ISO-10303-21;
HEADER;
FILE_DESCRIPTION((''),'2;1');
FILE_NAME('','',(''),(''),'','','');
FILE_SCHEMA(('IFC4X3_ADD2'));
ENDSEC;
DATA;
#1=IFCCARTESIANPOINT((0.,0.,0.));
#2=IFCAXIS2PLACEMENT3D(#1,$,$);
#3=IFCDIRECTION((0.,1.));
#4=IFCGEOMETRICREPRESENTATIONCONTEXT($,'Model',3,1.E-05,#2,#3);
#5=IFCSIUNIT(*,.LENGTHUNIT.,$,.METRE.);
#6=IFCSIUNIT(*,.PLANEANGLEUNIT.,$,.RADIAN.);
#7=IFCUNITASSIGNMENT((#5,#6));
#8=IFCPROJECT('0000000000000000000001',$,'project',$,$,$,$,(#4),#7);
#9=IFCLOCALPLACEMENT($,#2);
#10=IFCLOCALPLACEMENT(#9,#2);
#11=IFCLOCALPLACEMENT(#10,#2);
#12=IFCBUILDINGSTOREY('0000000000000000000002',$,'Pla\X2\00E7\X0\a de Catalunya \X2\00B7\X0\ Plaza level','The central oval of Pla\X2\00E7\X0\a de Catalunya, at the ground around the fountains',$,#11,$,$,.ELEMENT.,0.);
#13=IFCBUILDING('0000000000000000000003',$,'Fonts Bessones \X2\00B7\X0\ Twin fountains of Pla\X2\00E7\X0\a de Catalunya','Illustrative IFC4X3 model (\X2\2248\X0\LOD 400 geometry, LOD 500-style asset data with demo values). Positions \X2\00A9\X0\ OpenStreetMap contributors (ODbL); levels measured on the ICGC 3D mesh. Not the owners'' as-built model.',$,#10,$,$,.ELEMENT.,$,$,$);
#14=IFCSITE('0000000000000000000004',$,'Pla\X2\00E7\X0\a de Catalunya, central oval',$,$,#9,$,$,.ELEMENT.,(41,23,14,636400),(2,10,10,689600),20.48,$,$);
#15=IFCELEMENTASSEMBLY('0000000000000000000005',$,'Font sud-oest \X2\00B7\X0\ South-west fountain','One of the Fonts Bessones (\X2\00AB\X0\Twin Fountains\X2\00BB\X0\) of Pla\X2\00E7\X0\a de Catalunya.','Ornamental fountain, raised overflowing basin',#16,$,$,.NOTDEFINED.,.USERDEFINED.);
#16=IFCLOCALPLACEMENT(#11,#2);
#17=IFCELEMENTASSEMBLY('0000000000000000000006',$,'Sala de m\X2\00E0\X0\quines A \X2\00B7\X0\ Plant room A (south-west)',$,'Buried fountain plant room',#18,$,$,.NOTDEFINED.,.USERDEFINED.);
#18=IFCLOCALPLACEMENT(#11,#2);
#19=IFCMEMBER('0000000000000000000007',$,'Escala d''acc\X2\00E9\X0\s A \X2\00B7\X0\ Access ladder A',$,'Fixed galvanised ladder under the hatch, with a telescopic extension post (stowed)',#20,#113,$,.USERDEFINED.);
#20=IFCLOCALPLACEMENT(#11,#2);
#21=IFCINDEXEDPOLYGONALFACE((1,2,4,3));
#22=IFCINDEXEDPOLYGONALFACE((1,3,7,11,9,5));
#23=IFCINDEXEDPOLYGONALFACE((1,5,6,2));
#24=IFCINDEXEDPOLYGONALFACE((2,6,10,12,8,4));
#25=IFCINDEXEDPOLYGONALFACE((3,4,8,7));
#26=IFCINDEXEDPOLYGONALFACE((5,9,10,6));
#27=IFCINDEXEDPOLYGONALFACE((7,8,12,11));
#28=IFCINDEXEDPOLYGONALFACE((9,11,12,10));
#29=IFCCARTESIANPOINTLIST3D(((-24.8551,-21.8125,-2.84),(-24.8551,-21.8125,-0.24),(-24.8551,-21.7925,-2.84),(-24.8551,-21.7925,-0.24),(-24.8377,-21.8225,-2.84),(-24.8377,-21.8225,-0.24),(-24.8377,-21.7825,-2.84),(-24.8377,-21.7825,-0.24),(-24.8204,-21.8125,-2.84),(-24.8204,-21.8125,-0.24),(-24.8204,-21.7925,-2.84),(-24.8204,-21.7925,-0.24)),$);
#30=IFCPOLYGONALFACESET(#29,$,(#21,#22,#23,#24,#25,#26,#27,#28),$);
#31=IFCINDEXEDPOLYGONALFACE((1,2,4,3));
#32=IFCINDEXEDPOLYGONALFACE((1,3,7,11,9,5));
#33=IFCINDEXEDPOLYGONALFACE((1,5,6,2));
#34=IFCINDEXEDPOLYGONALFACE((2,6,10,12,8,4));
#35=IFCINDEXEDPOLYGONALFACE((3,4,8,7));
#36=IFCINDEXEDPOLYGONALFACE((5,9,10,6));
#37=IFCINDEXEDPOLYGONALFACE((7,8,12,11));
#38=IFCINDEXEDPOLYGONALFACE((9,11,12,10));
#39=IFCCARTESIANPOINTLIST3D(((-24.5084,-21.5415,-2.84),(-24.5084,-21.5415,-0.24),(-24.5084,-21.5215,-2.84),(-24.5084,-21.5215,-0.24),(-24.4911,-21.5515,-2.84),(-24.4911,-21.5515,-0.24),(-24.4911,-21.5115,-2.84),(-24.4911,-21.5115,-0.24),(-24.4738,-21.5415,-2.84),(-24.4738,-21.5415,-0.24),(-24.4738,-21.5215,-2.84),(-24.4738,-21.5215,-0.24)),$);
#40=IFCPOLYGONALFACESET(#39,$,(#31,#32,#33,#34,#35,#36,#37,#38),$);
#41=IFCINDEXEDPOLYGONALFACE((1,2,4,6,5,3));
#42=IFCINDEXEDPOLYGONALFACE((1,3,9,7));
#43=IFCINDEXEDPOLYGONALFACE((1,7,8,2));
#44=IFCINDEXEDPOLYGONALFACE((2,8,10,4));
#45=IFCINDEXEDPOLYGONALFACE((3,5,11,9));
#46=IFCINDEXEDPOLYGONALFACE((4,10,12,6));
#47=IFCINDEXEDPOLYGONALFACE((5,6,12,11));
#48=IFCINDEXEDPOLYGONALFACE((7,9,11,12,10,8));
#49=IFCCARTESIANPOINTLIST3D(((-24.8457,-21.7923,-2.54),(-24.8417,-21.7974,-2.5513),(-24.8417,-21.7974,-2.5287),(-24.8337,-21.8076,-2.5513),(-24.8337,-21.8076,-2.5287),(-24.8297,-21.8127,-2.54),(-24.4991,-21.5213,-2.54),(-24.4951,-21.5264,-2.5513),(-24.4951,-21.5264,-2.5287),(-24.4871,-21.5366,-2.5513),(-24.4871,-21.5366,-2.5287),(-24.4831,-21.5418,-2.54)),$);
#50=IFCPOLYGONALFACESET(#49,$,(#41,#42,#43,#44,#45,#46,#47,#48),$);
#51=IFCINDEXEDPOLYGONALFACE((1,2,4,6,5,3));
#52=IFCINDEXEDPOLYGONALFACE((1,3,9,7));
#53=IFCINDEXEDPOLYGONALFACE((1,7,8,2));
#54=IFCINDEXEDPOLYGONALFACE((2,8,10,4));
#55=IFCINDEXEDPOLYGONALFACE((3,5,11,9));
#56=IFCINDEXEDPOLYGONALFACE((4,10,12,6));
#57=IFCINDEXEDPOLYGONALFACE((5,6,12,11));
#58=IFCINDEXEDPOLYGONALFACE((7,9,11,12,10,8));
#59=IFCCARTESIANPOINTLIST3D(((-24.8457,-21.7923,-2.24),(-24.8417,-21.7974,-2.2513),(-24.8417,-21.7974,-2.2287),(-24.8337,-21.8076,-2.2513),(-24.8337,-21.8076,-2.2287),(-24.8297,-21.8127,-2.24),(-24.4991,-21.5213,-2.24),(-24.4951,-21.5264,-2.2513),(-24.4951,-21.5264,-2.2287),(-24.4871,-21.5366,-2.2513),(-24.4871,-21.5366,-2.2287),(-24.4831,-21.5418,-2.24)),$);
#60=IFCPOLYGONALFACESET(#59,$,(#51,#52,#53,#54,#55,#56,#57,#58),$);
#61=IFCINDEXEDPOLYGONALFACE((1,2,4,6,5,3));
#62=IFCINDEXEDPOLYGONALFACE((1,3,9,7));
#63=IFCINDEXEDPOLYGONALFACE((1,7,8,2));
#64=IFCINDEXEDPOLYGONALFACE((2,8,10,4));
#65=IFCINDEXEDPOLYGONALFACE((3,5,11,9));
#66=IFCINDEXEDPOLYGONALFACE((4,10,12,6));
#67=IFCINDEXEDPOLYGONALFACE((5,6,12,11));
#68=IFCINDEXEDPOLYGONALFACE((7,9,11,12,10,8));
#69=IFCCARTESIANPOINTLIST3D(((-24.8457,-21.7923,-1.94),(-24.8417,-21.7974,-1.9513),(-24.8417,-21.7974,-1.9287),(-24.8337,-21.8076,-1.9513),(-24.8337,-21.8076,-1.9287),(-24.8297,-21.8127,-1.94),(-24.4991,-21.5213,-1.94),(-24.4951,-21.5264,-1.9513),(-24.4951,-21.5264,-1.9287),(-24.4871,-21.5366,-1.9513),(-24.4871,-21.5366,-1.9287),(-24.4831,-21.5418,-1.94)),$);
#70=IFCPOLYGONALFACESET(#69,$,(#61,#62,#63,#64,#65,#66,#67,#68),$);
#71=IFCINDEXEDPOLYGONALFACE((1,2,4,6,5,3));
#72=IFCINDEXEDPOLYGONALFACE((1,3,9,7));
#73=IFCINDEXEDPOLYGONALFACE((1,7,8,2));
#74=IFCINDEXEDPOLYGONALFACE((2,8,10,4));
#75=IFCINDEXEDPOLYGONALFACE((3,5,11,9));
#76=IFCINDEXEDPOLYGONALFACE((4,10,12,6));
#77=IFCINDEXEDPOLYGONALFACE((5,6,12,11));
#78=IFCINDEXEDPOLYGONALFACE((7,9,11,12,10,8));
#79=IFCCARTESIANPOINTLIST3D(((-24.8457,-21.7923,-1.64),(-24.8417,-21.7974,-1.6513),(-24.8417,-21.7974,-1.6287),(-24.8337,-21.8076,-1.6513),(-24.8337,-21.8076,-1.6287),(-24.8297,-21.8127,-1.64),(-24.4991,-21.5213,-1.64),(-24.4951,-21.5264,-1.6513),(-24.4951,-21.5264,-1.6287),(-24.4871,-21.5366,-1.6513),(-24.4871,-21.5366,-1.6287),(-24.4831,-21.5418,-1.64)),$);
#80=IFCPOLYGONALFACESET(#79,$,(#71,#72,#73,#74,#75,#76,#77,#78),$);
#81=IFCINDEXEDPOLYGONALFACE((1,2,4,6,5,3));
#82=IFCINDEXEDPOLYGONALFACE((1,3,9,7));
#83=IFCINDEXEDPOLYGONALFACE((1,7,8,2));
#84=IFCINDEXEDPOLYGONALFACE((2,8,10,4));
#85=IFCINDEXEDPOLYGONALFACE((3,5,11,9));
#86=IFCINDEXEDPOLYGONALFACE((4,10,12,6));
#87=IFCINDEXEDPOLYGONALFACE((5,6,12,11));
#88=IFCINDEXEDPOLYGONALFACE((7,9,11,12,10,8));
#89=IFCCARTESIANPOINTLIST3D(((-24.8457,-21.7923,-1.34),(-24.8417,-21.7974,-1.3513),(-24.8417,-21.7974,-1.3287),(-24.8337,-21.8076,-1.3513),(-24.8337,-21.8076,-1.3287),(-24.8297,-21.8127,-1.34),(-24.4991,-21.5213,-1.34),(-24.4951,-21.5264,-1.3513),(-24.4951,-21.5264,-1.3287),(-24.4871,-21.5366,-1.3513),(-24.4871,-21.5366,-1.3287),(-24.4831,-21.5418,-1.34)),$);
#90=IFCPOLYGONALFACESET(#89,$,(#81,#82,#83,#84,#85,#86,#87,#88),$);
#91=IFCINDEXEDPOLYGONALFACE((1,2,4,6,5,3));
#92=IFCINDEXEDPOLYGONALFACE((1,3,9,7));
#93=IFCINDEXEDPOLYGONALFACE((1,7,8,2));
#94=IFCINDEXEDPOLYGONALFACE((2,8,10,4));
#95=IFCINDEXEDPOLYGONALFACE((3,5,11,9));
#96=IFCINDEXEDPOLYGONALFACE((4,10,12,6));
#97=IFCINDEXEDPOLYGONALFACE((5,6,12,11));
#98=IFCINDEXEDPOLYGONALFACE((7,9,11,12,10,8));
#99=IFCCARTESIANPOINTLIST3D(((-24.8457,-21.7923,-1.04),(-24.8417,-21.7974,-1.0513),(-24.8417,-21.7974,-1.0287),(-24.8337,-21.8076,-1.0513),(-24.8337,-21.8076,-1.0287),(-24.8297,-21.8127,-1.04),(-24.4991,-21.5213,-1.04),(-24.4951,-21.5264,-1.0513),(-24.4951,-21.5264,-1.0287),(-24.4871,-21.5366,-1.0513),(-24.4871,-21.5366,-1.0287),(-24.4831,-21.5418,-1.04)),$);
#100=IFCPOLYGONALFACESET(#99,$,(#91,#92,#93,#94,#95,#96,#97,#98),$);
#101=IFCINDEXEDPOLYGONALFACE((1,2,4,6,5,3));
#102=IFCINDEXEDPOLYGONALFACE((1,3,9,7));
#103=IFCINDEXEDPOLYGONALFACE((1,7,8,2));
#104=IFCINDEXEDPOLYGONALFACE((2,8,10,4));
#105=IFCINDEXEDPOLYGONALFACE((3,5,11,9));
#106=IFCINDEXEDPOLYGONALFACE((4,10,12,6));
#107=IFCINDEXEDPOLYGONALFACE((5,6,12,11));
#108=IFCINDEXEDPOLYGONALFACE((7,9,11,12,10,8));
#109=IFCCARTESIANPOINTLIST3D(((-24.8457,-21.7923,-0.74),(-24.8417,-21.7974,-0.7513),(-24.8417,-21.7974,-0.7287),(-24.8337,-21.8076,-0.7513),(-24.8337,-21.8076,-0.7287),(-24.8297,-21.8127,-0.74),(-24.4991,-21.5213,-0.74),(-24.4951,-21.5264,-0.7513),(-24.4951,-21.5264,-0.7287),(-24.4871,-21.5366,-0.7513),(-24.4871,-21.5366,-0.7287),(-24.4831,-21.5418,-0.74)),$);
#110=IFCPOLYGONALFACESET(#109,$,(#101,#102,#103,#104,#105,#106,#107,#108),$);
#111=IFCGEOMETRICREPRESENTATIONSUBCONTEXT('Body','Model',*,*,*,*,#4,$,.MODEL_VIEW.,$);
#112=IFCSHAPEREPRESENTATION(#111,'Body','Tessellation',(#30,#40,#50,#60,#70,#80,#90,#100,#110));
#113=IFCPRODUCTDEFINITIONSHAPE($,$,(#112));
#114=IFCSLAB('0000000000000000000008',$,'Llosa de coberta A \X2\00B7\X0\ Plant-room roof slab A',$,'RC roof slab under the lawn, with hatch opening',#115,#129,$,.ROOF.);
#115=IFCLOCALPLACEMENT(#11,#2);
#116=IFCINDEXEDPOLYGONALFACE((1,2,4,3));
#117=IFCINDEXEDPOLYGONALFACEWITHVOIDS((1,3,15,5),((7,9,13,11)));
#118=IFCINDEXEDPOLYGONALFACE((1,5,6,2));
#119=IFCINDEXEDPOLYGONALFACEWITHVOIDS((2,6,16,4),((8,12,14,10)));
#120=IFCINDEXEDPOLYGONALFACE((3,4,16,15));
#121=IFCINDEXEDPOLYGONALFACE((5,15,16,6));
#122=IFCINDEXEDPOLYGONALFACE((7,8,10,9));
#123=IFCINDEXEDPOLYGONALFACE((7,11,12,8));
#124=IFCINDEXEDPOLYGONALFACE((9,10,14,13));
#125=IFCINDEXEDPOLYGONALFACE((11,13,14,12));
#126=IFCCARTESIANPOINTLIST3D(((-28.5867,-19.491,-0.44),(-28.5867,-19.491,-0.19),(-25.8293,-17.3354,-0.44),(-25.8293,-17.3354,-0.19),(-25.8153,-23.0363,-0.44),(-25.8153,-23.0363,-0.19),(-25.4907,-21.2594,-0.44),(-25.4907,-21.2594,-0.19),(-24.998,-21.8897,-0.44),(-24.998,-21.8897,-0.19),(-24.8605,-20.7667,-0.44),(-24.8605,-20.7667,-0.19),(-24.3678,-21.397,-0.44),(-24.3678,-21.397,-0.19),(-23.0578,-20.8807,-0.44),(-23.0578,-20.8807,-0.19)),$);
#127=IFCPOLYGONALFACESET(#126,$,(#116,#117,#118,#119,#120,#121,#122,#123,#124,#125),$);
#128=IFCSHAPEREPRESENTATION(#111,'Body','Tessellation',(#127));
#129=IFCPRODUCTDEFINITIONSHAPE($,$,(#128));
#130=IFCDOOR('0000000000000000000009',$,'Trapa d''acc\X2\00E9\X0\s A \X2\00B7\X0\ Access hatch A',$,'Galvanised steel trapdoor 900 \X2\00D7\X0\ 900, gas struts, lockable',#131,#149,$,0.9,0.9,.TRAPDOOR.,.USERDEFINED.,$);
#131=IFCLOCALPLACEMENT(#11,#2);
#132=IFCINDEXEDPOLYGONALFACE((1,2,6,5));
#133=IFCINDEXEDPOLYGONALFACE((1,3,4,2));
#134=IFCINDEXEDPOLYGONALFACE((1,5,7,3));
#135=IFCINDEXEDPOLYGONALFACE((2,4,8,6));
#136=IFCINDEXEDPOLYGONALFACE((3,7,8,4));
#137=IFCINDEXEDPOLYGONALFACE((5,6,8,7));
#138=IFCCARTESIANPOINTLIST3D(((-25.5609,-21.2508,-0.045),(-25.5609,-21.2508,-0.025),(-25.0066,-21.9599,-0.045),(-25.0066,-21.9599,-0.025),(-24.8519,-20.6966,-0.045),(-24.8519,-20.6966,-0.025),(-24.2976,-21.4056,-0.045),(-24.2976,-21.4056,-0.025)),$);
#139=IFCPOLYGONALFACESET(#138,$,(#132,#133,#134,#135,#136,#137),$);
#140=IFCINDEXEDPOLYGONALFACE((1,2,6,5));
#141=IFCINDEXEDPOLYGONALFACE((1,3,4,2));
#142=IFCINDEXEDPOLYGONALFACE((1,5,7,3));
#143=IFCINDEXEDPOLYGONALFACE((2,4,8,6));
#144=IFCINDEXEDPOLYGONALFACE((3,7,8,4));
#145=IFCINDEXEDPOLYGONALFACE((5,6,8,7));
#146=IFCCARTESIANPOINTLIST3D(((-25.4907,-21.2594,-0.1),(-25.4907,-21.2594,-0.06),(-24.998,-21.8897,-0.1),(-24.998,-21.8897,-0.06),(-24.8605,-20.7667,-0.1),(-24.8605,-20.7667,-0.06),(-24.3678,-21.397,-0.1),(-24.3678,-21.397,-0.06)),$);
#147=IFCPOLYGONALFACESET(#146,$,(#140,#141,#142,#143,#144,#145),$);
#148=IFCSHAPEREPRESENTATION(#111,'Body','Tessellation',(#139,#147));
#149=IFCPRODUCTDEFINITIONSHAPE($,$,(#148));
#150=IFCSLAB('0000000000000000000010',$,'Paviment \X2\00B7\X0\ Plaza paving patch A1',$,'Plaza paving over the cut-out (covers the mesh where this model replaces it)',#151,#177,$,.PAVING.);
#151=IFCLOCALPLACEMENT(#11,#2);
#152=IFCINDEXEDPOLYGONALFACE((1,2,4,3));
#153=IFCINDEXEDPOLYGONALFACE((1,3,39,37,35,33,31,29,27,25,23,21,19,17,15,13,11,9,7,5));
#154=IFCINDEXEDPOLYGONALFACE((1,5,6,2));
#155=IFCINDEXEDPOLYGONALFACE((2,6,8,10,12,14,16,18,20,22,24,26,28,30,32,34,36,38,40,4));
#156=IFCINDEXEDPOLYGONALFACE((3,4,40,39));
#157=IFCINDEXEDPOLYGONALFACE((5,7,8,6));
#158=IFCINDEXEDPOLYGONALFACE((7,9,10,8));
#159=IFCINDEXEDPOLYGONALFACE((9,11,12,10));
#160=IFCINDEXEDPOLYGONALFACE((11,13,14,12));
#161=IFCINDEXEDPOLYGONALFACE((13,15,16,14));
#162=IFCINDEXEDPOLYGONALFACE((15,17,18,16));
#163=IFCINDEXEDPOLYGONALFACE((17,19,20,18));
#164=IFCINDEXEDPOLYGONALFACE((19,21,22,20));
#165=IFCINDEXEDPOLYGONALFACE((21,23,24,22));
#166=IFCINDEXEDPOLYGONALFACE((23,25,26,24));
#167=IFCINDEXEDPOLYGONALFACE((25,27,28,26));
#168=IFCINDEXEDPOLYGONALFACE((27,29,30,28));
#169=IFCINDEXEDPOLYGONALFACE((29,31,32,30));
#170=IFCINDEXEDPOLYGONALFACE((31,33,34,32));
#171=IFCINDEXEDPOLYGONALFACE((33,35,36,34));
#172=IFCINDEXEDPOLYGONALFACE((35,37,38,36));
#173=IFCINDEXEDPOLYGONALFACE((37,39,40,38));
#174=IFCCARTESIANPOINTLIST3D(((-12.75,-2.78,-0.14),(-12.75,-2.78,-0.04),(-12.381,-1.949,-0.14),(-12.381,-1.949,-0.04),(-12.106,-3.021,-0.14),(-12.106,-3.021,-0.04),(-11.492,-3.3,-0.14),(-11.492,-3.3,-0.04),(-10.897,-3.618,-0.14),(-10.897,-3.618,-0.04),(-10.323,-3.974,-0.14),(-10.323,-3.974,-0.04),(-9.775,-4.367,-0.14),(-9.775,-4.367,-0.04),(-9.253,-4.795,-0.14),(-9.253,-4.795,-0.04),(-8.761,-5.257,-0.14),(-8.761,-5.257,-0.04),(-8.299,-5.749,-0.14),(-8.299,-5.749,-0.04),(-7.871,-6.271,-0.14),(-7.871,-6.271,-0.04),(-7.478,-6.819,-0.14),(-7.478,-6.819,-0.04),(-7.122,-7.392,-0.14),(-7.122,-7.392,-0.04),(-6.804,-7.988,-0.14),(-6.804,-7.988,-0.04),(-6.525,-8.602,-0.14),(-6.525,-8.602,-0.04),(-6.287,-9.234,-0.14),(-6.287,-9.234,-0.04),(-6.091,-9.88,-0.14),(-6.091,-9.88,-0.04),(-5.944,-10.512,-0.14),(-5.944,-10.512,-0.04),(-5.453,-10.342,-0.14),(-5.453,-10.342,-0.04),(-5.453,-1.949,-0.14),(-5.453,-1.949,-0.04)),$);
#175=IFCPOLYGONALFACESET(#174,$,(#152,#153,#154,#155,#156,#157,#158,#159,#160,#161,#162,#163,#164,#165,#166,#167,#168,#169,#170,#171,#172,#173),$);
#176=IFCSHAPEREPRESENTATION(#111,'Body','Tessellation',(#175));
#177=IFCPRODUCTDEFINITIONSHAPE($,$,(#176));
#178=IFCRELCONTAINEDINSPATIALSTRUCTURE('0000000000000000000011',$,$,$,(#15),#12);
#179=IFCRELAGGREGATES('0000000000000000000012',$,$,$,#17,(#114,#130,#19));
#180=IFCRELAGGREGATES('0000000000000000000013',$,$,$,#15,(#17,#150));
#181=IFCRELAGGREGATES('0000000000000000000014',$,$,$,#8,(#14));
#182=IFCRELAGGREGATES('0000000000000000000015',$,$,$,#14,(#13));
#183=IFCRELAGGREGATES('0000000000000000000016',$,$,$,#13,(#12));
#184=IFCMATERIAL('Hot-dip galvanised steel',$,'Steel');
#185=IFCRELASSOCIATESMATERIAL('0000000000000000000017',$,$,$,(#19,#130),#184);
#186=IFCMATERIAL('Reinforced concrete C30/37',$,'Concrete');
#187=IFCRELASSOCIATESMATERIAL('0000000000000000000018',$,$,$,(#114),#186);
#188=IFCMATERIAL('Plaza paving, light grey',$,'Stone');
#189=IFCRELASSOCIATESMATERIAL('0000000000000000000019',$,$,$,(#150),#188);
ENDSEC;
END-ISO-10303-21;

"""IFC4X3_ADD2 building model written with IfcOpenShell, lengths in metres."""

from ifc_helpers import new_model, si_unit, direction, frame, frame_2d, origin, place, context, subcontext, project, spatial, polyline, rectangle, outline, extrude, material, element, fill, aggregate, save


model = new_model("IFC4X3_ADD2")

# Units and contexts
model_context = context("Model", 3, precision=1e-05, world=origin(), true_north=direction((0.0, 1.0)))
body_context = subcontext(model_context, "Body", "Model", "MODEL_VIEW")
ifc_project = project(units=[si_unit("LENGTHUNIT", "METRE"), si_unit("PLANEANGLEUNIT", "RADIAN")], contexts=[model_context])

# Site, building, storey
site_placement = place(None, origin())
site = spatial("IfcSite", under=ifc_project, at=site_placement, Name="Plaça de Catalunya, central oval", CompositionType="ELEMENT", RefLatitude=(41, 23, 14, 636400), RefLongitude=(2, 10, 10, 689600), RefElevation=20.48)
building_placement = place(site_placement, origin())
building = spatial("IfcBuilding", under=site, at=building_placement, Name="Fonts Bessones · Twin fountains of Plaça de Catalunya", Description="Illustrative IFC4X3 model (≈LOD 400 geometry, LOD 500-style asset data with demo values). Positions © OpenStreetMap contributors (ODbL); levels measured on the ICGC 3D mesh. Not the owners' as-built model.", CompositionType="ELEMENT")
storey_placement = place(building_placement, origin())
storey = spatial("IfcBuildingStorey", under=building, at=storey_placement, Name="Plaça de Catalunya · Plaza level", Description="The central oval of Plaça de Catalunya, at the ground around the fountains", CompositionType="ELEMENT", Elevation=0.0)

# Shared definitions
ifc_material_1 = material(Name="Reinforced concrete C30/37", Category="Concrete")

# Element assemblies, member, slabs, opening, door
assembly_1_placement = place(building_placement, origin())
assembly_1 = element("IfcElementAssembly", 1, at=assembly_1_placement, inside=storey, Name="Font sud-oest · South-west fountain", Description="One of the Fonts Bessones («Twin Fountains») of Plaça de Catalunya.", ObjectType="Ornamental fountain, raised overflowing basin", AssemblyPlace="NOTDEFINED", PredefinedType="USERDEFINED")
assembly_2_placement = place(building_placement, origin())
assembly_2 = element("IfcElementAssembly", 2, at=assembly_2_placement, Name="Sala de màquines A · Plant room A (south-west)", ObjectType="Buried fountain plant room", AssemblyPlace="NOTDEFINED", PredefinedType="USERDEFINED")
ifc_material_2 = material(Name="Hot-dip galvanised steel", Category="Steel")
member_placement = place(building_placement, origin())
member = element("IfcMember", 3, at=member_placement, material=ifc_material_2, Name="Escala d'accés A · Access ladder A", ObjectType="Fixed galvanised ladder under the hatch, with a telescopic extension post (stowed)", PredefinedType="USERDEFINED", context=body_context, shape_type="SweptSolid", body=[
    extrude(outline(polyline([(0.02, 0.0), (0.01, 0.0173), (-0.01, 0.0173), (-0.02, 0.0), (-0.01, -0.0173), (0.01, -0.0173), (0.02, 0.0)])), frame((-24.8377, -21.8025, -2.84), z_axis=(0.0, 0.0, 1.0), x_axis=(0.0, 1.0, 0.0)), (0.0, 0.0, 1.0), 2.6),
    extrude(outline(polyline([(0.02, 0.0), (0.01, 0.0173), (-0.01, 0.0173), (-0.02, 0.0), (-0.01, -0.0173), (0.01, -0.0173), (0.02, 0.0)])), frame((-24.4911, -21.5315, -2.84), z_axis=(0.0, 0.0, 1.0), x_axis=(0.0, 1.0, 0.0)), (0.0, 0.0, 1.0), 2.6),
    extrude(outline(polyline([(0.013, 0.0), (0.0065, 0.0113), (-0.0065, 0.0113), (-0.013, 0.0), (-0.0065, -0.0113), (0.0065, -0.0113), (0.013, 0.0)])), frame((-24.8377, -21.8025, -2.54), z_axis=(0.787844, 0.615875, 0.0), x_axis=(0.615875, -0.787844, 0.0)), (0.0, 0.0, 1.0), 0.44),
    extrude(outline(polyline([(0.013, 0.0), (0.0065, 0.0113), (-0.0065, 0.0113), (-0.013, 0.0), (-0.0065, -0.0113), (0.0065, -0.0113), (0.013, 0.0)])), frame((-24.8377, -21.8025, -2.24), z_axis=(0.787844, 0.615875, 0.0), x_axis=(0.615875, -0.787844, 0.0)), (0.0, 0.0, 1.0), 0.44),
    extrude(outline(polyline([(0.013, 0.0), (0.0065, 0.0113), (-0.0065, 0.0113), (-0.013, 0.0), (-0.0065, -0.0113), (0.0065, -0.0113), (0.013, 0.0)])), frame((-24.8377, -21.8025, -1.94), z_axis=(0.787844, 0.615875, 0.0), x_axis=(0.615875, -0.787844, 0.0)), (0.0, 0.0, 1.0), 0.44),
    extrude(outline(polyline([(0.013, 0.0), (0.0065, 0.0113), (-0.0065, 0.0113), (-0.013, 0.0), (-0.0065, -0.0113), (0.0065, -0.0113), (0.013, 0.0)])), frame((-24.8377, -21.8025, -1.64), z_axis=(0.787844, 0.615875, 0.0), x_axis=(0.615875, -0.787844, 0.0)), (0.0, 0.0, 1.0), 0.44),
    extrude(outline(polyline([(0.013, 0.0), (0.0065, 0.0113), (-0.0065, 0.0113), (-0.013, 0.0), (-0.0065, -0.0113), (0.0065, -0.0113), (0.013, 0.0)])), frame((-24.8377, -21.8025, -1.34), z_axis=(0.787844, 0.615875, 0.0), x_axis=(0.615875, -0.787844, 0.0)), (0.0, 0.0, 1.0), 0.44),
    extrude(outline(polyline([(0.013, 0.0), (0.0065, 0.0113), (-0.0065, 0.0113), (-0.013, 0.0), (-0.0065, -0.0113), (0.0065, -0.0113), (0.013, 0.0)])), frame((-24.8377, -21.8025, -1.04), z_axis=(0.787844, 0.615875, 0.0), x_axis=(0.615875, -0.787844, 0.0)), (0.0, 0.0, 1.0), 0.44),
    extrude(outline(polyline([(0.013, 0.0), (0.0065, 0.0113), (-0.0065, 0.0113), (-0.013, 0.0), (-0.0065, -0.0113), (0.0065, -0.0113), (0.013, 0.0)])), frame((-24.8377, -21.8025, -0.74), z_axis=(0.787844, 0.615875, 0.0), x_axis=(0.615875, -0.787844, 0.0)), (0.0, 0.0, 1.0), 0.44),
])
slab_1_placement = place(building_placement, origin())
slab_1 = element("IfcSlab", 4, at=slab_1_placement, material=ifc_material_1, Name="Llosa de coberta A · Plant-room roof slab A", ObjectType="RC roof slab under the lawn, with hatch opening", PredefinedType="ROOF", context=body_context, shape_type="SweptSolid", body=[
    extrude(rectangle(XDim=4.5, YDim=3.5, at=frame_2d((0.0, 0.0), x_axis=(0.615875, -0.787844))), frame((-25.8223, -20.1859, -0.44)), (0.0, 0.0, 1.0), 0.25),
])
opening_placement = place(building_placement, origin())
opening = element("IfcOpeningElement", 5, at=opening_placement, cuts=slab_1, PredefinedType="OPENING", context=body_context, shape_type="SweptSolid", body=[
    extrude(rectangle(XDim=0.8, YDim=0.8, at=frame_2d((0.0, 0.0), x_axis=(0.615875, -0.787844))), frame((-24.9292, -21.3282, -0.49)), (0.0, 0.0, 1.0), 0.35),
])
door_placement = place(building_placement, origin())
door = element("IfcDoor", 6, at=door_placement, material=ifc_material_2, Name="Trapa d'accés A · Access hatch A", ObjectType="Galvanised steel trapdoor 900 × 900, gas struts, lockable", OperationType="USERDEFINED", OverallHeight=0.9, OverallWidth=0.9, PredefinedType="TRAPDOOR", context=body_context, shape_type="SweptSolid", body=[
    extrude(rectangle(XDim=0.9, YDim=0.9, at=frame_2d((0.0, 0.0), x_axis=(0.615875, -0.787844))), frame((-24.9292, -21.3282, -0.045)), (0.0, 0.0, 1.0), 0.02),
    extrude(rectangle(XDim=0.8, YDim=0.8, at=frame_2d((0.0, 0.0), x_axis=(0.615875, -0.787844))), frame((-24.9292, -21.3282, -0.1)), (0.0, 0.0, 1.0), 0.04),
])
fill(opening, door)
ifc_material_3 = material(Name="Plaza paving, light grey", Category="Stone")
slab_2_placement = place(building_placement, origin())
slab_2 = element("IfcSlab", 7, at=slab_2_placement, material=ifc_material_3, Name="Paviment · Plaza paving patch A1", ObjectType="Plaza paving over the cut-out (covers the mesh where this model replaces it)", PredefinedType="PAVING", context=body_context, shape_type="SweptSolid", body=[
    extrude(outline(polyline([(-5.453, -1.949), (-5.453, -10.342), (-5.944, -10.512), (-6.091, -9.88), (-6.287, -9.234), (-6.525, -8.602), (-6.804, -7.988), (-7.122, -7.392), (-7.478, -6.819), (-7.871, -6.271), (-8.299, -5.749), (-8.761, -5.257), (-9.253, -4.795), (-9.775, -4.367), (-10.323, -3.974), (-10.897, -3.618), (-11.492, -3.3), (-12.106, -3.021), (-12.75, -2.78), (-12.381, -1.949), (-5.453, -1.949)]), holes=[]), frame((0.0, 0.0, -0.14)), (0.0, 0.0, 1.0), 0.1),
])

aggregate(assembly_2, [slab_1, door, member])

aggregate(assembly_1, [assembly_2, slab_2])

save(model, "model.ifc")
